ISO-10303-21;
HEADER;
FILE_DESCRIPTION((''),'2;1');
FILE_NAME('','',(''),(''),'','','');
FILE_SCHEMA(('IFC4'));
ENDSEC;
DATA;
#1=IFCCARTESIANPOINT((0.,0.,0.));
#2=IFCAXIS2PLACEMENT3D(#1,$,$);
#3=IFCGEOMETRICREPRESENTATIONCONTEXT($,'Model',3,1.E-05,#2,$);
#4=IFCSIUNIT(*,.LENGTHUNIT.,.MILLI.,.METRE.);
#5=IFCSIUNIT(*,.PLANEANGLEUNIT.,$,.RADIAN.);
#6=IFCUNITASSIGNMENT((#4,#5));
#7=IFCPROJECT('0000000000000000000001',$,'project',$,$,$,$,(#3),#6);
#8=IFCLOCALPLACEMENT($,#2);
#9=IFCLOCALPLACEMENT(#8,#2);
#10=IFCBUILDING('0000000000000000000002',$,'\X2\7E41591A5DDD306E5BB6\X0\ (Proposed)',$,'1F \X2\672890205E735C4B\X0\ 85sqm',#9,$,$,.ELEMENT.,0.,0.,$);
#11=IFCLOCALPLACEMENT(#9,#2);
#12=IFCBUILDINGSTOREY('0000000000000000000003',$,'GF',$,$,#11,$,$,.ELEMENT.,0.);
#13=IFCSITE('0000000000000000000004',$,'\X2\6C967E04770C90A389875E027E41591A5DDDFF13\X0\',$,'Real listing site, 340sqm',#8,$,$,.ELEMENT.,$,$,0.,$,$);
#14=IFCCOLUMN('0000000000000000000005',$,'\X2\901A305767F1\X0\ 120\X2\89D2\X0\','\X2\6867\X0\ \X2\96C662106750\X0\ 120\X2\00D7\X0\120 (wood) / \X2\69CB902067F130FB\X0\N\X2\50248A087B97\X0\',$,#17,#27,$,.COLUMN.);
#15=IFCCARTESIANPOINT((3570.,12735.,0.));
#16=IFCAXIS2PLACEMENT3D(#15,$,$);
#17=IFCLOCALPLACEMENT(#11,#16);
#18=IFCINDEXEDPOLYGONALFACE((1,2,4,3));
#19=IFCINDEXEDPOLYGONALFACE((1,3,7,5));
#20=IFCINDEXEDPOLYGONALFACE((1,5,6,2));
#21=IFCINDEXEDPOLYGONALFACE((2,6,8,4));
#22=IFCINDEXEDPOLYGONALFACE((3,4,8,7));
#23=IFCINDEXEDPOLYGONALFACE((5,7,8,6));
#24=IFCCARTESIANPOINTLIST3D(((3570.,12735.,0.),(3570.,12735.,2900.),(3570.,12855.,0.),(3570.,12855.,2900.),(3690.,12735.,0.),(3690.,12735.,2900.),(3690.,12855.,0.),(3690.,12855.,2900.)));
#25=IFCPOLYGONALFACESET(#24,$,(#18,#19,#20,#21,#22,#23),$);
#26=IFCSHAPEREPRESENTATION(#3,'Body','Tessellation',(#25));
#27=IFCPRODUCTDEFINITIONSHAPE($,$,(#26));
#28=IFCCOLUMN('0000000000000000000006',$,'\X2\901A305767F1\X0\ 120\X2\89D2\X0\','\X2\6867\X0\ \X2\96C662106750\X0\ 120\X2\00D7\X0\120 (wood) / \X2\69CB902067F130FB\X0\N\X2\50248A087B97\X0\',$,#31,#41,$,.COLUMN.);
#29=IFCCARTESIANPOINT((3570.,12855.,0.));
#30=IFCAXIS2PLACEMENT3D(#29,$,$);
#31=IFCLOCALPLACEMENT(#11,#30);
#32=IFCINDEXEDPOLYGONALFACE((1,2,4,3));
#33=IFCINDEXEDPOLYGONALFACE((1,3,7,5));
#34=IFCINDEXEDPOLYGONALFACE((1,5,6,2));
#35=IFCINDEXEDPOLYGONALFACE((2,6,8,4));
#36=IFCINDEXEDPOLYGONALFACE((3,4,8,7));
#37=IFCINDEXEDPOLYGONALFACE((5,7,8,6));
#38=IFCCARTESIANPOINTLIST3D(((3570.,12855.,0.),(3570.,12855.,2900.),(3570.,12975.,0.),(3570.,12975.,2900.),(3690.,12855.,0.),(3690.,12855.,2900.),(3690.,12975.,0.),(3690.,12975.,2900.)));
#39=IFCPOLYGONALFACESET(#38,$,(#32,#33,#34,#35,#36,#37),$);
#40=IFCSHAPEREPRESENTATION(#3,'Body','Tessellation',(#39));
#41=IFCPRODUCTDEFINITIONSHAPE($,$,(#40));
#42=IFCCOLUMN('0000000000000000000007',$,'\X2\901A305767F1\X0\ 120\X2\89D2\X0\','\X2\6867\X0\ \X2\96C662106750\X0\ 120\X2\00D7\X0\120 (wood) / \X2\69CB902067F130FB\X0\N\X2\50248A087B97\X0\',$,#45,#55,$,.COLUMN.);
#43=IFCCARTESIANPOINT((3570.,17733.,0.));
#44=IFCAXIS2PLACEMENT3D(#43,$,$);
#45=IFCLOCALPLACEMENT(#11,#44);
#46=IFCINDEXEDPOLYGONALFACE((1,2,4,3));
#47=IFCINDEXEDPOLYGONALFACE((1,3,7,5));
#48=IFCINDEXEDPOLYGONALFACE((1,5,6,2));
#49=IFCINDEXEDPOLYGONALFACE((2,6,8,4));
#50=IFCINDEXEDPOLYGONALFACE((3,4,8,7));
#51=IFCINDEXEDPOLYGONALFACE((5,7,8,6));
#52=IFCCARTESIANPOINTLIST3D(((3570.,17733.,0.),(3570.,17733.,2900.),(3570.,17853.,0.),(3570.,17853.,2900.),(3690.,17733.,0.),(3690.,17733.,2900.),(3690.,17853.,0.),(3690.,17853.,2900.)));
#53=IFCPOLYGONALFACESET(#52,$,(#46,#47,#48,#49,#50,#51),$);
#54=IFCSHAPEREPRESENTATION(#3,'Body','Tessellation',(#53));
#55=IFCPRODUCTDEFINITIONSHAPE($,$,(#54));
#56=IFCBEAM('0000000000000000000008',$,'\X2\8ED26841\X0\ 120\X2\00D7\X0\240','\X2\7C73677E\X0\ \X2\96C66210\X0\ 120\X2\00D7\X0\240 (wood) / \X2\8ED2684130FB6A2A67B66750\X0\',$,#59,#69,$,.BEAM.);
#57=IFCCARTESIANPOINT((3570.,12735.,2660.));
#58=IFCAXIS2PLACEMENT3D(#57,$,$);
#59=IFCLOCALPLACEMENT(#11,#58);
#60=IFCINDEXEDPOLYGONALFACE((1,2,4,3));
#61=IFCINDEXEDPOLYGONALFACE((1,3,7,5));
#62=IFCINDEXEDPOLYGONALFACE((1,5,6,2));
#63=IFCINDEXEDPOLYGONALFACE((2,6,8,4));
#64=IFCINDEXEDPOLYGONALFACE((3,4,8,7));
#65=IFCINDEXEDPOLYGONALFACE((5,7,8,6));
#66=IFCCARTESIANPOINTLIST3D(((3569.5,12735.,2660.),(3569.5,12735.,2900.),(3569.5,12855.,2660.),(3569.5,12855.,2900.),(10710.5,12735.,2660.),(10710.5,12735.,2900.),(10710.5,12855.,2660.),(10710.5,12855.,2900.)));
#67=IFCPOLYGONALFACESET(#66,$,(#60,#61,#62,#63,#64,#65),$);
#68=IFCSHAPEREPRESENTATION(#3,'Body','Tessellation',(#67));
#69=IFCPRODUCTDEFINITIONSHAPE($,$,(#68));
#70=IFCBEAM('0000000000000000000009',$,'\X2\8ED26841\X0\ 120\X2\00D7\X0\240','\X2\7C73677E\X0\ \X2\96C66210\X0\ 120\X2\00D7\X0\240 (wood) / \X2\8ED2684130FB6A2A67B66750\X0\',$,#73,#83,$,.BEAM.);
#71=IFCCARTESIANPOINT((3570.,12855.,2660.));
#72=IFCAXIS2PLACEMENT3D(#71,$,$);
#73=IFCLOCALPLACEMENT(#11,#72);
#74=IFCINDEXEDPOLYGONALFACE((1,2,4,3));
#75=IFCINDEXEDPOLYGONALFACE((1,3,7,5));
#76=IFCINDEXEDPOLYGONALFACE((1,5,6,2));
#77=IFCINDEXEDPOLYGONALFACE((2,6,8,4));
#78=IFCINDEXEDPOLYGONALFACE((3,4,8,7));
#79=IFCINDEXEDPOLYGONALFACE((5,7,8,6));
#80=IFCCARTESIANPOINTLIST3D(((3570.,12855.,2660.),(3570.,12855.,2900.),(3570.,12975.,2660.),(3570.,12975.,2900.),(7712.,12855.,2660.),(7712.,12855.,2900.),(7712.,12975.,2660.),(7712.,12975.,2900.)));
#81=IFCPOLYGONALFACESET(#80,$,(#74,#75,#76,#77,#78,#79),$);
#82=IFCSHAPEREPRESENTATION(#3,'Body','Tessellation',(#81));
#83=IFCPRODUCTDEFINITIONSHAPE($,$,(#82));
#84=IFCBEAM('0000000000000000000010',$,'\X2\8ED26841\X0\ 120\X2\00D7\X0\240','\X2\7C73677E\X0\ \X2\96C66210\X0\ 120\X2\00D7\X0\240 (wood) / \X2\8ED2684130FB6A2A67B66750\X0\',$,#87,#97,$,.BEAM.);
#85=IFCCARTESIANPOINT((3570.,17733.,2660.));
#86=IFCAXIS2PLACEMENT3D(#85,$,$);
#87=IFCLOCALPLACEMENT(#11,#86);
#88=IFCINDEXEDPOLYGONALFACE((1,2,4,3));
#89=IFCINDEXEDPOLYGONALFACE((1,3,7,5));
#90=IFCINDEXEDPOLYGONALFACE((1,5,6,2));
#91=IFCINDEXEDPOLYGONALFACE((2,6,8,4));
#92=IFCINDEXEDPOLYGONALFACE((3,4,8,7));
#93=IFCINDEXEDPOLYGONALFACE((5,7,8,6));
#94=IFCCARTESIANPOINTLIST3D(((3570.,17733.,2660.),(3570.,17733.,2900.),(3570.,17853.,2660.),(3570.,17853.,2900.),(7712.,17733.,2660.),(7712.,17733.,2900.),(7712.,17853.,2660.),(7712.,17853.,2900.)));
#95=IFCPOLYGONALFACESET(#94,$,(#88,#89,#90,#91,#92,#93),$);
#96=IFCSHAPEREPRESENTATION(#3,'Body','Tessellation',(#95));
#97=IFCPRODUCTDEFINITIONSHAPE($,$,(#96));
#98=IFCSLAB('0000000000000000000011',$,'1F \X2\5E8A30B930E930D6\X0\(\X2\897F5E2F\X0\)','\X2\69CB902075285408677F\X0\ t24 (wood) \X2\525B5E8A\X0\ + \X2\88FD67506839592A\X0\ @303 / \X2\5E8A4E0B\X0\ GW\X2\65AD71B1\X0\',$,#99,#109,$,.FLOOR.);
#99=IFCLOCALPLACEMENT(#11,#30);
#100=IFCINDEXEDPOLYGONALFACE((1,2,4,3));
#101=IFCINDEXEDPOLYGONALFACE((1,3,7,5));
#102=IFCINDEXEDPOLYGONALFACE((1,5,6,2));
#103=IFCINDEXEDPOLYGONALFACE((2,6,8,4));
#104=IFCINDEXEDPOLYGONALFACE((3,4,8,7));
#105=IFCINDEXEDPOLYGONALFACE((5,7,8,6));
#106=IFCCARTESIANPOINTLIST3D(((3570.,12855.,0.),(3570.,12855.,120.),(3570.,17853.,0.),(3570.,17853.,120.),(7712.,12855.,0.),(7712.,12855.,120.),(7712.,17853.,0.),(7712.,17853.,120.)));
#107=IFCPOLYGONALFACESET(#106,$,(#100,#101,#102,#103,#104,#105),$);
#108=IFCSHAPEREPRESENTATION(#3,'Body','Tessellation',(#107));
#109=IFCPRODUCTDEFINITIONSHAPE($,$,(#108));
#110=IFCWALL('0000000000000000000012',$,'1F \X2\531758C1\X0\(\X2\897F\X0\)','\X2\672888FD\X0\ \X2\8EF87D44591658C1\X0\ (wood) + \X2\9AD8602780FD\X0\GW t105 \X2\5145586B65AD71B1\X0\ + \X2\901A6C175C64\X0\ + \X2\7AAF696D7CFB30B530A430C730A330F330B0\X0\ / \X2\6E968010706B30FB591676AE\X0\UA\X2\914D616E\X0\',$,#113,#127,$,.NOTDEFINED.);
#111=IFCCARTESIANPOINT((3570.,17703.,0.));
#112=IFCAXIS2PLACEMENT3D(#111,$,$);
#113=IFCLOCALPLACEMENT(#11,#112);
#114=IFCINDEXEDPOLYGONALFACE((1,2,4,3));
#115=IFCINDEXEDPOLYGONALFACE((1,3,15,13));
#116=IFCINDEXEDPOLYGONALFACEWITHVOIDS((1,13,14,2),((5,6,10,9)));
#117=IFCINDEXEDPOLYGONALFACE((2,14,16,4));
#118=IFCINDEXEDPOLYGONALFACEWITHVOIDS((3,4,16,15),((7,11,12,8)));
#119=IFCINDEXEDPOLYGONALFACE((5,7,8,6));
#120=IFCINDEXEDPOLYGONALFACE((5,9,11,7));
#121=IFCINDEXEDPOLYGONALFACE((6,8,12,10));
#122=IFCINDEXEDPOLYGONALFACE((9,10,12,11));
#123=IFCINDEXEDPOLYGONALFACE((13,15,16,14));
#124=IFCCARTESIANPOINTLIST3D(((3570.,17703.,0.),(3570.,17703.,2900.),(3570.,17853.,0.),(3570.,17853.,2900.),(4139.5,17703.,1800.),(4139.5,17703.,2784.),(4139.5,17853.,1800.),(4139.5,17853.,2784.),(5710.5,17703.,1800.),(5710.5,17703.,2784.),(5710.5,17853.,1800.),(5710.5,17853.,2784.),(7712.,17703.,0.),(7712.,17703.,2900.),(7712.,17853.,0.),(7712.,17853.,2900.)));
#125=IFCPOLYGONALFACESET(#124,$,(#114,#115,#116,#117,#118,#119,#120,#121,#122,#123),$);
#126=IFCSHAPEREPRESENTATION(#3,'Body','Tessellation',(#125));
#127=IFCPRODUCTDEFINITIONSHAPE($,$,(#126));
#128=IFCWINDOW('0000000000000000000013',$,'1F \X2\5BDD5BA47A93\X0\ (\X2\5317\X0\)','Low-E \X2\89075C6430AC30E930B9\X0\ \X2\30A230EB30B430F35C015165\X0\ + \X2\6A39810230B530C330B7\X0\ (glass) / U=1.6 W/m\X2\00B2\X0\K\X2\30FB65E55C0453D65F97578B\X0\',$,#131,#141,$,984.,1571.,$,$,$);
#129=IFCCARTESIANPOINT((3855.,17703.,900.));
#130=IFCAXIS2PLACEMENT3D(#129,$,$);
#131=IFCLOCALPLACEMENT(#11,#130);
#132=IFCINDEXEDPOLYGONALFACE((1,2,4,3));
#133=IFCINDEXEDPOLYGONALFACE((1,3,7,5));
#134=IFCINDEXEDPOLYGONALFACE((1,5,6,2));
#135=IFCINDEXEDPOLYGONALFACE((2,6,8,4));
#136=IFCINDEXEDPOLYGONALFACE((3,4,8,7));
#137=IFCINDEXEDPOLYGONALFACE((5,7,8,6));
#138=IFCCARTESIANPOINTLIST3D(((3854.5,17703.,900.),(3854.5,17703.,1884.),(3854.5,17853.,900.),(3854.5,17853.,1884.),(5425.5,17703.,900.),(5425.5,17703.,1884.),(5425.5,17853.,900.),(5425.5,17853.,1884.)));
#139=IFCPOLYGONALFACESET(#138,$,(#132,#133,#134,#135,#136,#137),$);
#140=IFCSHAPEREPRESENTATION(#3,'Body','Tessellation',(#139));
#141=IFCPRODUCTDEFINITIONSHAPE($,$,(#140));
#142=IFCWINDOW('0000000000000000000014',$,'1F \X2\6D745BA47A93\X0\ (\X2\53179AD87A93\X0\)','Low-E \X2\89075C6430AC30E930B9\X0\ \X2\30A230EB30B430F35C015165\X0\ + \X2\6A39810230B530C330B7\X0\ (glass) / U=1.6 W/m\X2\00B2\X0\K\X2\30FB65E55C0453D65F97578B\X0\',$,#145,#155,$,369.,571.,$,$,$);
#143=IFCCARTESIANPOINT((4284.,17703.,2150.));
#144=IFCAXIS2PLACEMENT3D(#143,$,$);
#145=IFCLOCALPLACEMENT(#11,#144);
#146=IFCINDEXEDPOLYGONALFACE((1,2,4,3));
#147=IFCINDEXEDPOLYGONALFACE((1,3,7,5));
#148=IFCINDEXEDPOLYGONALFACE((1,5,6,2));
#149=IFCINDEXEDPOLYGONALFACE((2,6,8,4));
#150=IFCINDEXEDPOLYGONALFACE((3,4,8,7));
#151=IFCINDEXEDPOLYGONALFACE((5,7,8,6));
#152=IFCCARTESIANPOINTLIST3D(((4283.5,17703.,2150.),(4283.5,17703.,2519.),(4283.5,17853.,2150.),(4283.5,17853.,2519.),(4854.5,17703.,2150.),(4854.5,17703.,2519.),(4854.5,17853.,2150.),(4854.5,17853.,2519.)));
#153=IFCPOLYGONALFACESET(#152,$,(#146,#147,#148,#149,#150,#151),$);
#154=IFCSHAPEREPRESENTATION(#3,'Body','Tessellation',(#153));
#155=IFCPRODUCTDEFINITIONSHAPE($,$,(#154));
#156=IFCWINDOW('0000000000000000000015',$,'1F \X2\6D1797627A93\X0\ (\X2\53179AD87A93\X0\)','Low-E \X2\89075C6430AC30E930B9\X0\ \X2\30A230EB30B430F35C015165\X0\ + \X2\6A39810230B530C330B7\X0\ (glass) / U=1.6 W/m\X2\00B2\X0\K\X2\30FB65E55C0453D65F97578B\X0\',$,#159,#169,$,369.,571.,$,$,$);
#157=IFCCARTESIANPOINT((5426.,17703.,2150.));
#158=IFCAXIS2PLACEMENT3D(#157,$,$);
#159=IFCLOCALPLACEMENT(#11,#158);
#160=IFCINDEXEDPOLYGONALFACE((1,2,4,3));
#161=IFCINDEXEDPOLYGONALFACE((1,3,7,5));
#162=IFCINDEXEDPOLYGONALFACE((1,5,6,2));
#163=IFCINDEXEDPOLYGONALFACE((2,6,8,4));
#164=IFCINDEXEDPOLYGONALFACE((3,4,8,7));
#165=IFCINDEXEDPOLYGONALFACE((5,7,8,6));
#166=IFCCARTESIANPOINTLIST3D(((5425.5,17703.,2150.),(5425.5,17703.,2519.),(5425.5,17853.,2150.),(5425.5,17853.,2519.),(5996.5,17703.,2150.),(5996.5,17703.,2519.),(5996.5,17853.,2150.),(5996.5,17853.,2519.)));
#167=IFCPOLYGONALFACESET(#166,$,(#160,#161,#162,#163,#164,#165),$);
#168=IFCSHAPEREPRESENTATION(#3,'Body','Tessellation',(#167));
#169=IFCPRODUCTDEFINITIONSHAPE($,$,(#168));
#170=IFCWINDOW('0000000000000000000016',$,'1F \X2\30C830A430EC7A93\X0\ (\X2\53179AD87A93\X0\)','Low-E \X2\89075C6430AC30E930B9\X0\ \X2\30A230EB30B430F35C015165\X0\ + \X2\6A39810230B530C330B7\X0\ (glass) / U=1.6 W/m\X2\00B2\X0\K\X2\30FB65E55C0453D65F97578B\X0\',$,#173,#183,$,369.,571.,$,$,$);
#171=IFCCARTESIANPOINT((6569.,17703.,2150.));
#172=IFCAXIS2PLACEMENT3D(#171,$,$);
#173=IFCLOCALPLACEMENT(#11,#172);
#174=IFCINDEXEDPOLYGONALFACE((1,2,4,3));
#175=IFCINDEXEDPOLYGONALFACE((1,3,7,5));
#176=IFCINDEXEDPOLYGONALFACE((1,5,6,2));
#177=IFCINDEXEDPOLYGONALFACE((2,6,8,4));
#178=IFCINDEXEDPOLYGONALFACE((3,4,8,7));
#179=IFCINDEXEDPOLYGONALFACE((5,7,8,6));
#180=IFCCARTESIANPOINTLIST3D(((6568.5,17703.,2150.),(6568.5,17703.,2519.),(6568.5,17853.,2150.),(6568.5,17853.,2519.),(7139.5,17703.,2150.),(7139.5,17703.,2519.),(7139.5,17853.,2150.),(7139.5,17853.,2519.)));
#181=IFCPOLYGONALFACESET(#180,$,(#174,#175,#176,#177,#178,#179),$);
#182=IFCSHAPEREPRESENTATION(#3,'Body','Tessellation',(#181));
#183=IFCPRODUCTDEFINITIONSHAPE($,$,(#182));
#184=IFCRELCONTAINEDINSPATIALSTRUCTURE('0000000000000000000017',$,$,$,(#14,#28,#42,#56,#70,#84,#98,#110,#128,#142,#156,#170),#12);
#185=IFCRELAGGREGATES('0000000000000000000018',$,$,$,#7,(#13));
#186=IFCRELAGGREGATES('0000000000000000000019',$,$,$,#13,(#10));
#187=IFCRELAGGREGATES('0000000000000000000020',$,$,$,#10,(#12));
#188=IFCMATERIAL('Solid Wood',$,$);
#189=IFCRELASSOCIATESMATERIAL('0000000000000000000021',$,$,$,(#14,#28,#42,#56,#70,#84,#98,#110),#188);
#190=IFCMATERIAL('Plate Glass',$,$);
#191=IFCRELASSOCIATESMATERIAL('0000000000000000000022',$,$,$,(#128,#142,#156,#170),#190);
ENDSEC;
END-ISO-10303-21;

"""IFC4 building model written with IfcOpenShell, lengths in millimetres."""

from ifc_helpers import new_model, si_unit, frame, frame_2d, origin, place, context, project, spatial, rectangle, extrude, material, element, fill, save


model = new_model("IFC4")

# Units and contexts
model_context = context("Model", 3, precision=1e-05, world=origin())
ifc_project = project(units=[si_unit("LENGTHUNIT", "METRE", prefix="MILLI"), si_unit("PLANEANGLEUNIT", "RADIAN")], contexts=[model_context])

# Site, building, storey
site_placement = place(None, origin())
site = spatial("IfcSite", under=ifc_project, at=site_placement, Name="沖縄県那覇市繁多川３", ObjectType="Real listing site, 340sqm", CompositionType="ELEMENT", RefElevation=0.0)
building_placement = place(site_placement, origin())
building = spatial("IfcBuilding", under=site, at=building_placement, Name="繁多川の家 (Proposed)", ObjectType="1F 木造平屋 85sqm", CompositionType="ELEMENT", ElevationOfRefHeight=0.0, ElevationOfTerrain=0.0)
storey_placement = place(building_placement, origin())
storey = spatial("IfcBuildingStorey", under=building, at=storey_placement, Name="GF", CompositionType="ELEMENT", Elevation=0.0)

# Columns
ifc_material_1 = material(Name="Solid Wood")
column_1_placement = place(storey_placement, frame((3570.0, 12735.0, 0.0)))
element("IfcColumn", 1, at=column_1_placement, inside=storey, material=ifc_material_1, Name="通し柱 120角", Description="桧 集成材 120×120 (wood) / 構造柱・N値計算", PredefinedType="COLUMN", context=model_context, shape_type="SweptSolid", body=[
    extrude(rectangle(XDim=120.0, YDim=120.0, at=frame_2d((60.0, 60.0))), frame((3570.0, 12735.0, 0.0)), (0.0, 0.0, 1.0), 2900.0),
])
column_2_placement = place(storey_placement, frame((3570.0, 12855.0, 0.0)))
element("IfcColumn", 2, at=column_2_placement, inside=storey, material=ifc_material_1, Name="通し柱 120角", Description="桧 集成材 120×120 (wood) / 構造柱・N値計算", PredefinedType="COLUMN", context=model_context, shape_type="SweptSolid", body=[
    extrude(rectangle(XDim=120.0, YDim=120.0, at=frame_2d((60.0, 60.0))), frame((3570.0, 12855.0, 0.0)), (0.0, 0.0, 1.0), 2900.0),
])
column_3_placement = place(storey_placement, frame((3570.0, 17733.0, 0.0)))
element("IfcColumn", 3, at=column_3_placement, inside=storey, material=ifc_material_1, Name="通し柱 120角", Description="桧 集成材 120×120 (wood) / 構造柱・N値計算", PredefinedType="COLUMN", context=model_context, shape_type="SweptSolid", body=[
    extrude(rectangle(XDim=120.0, YDim=120.0, at=frame_2d((60.0, 60.0))), frame((3570.0, 17733.0, 0.0)), (0.0, 0.0, 1.0), 2900.0),
])

# Beams
beam_1_placement = place(storey_placement, frame((3570.0, 12735.0, 2660.0)))
element("IfcBeam", 4, at=beam_1_placement, inside=storey, material=ifc_material_1, Name="軒桁 120×240", Description="米松 集成 120×240 (wood) / 軒桁・横架材", PredefinedType="BEAM", context=model_context, shape_type="SweptSolid", body=[
    extrude(rectangle(XDim=7141.0, YDim=120.0, at=frame_2d((3570.0, 60.0))), frame((3570.0, 12735.0, 2660.0)), (0.0, 0.0, 1.0), 240.0),
])
beam_2_placement = place(storey_placement, frame((3570.0, 12855.0, 2660.0)))
element("IfcBeam", 5, at=beam_2_placement, inside=storey, material=ifc_material_1, Name="軒桁 120×240", Description="米松 集成 120×240 (wood) / 軒桁・横架材", PredefinedType="BEAM", context=model_context, shape_type="SweptSolid", body=[
    extrude(rectangle(XDim=4142.0, YDim=120.0, at=frame_2d((2071.0, 60.0))), frame((3570.0, 12855.0, 2660.0)), (0.0, 0.0, 1.0), 240.0),
])
beam_3_placement = place(storey_placement, frame((3570.0, 17733.0, 2660.0)))
element("IfcBeam", 6, at=beam_3_placement, inside=storey, material=ifc_material_1, Name="軒桁 120×240", Description="米松 集成 120×240 (wood) / 軒桁・横架材", PredefinedType="BEAM", context=model_context, shape_type="SweptSolid", body=[
    extrude(rectangle(XDim=4142.0, YDim=120.0, at=frame_2d((2071.0, 60.0))), frame((3570.0, 17733.0, 2660.0)), (0.0, 0.0, 1.0), 240.0),
])

# Slab
slab_placement = place(storey_placement, frame((3570.0, 12855.0, 0.0)))
element("IfcSlab", 7, at=slab_placement, inside=storey, material=ifc_material_1, Name="1F 床スラブ(西帯)", Description="構造用合板 t24 (wood) 剛床 + 製材根太 @303 / 床下 GW断熱", PredefinedType="FLOOR", context=model_context, shape_type="SweptSolid", body=[
    extrude(rectangle(XDim=4142.0, YDim=4998.0, at=frame_2d((2071.0, 2499.0))), frame((3570.0, 12855.0, 0.0)), (0.0, 0.0, 1.0), 120.0),
])

# Wall, openings, windows
wall_1_placement = place(storey_placement, frame((3570.0, 17703.0, 0.0)))
wall_1 = element("IfcWall", 8, at=wall_1_placement, inside=storey, material=ifc_material_1, Name="1F 北壁(西)", Description="木製 軸組外壁 (wood) + 高性能GW t105 充填断熱 + 通気層 + 窯業系サイディング / 準耐火・外皮UA配慮", PredefinedType="NOTDEFINED", context=model_context, shape_type="SweptSolid", body=[
    extrude(rectangle(XDim=4142.0, YDim=150.0, at=frame_2d((2071.0, 75.0))), frame((3570.0, 17703.0, 0.0)), (0.0, 0.0, 1.0), 2900.0),
])
opening_1_placement = place(storey_placement, frame((3855.0, 17703.0, 900.0)))
opening_1 = element("IfcOpeningElement", 9, at=opening_1_placement, cuts=wall_1, PredefinedType="NOTDEFINED", context=model_context, shape_type="SweptSolid", body=[
    extrude(rectangle(XDim=1571.0, YDim=150.0, at=frame_2d((785.0, 75.0))), frame((3855.0, 17703.0, 900.0)), (0.0, 0.0, 1.0), 984.0),
])
opening_2_placement = place(storey_placement, frame((4284.0, 17703.0, 2150.0)))
opening_2 = element("IfcOpeningElement", 10, at=opening_2_placement, cuts=wall_1, PredefinedType="NOTDEFINED", context=model_context, shape_type="SweptSolid", body=[
    extrude(rectangle(XDim=571.0, YDim=150.0, at=frame_2d((285.0, 75.0))), frame((4284.0, 17703.0, 2150.0)), (0.0, 0.0, 1.0), 369.0),
])
opening_3_placement = place(storey_placement, frame((5426.0, 17703.0, 2150.0)))
opening_3 = element("IfcOpeningElement", 11, at=opening_3_placement, cuts=wall_1, PredefinedType="NOTDEFINED", context=model_context, shape_type="SweptSolid", body=[
    extrude(rectangle(XDim=571.0, YDim=150.0, at=frame_2d((285.0, 75.0))), frame((5426.0, 17703.0, 2150.0)), (0.0, 0.0, 1.0), 369.0),
])
opening_4_placement = place(storey_placement, frame((6569.0, 17703.0, 2150.0)))
opening_4 = element("IfcOpeningElement", 12, at=opening_4_placement, cuts=wall_1, PredefinedType="NOTDEFINED", context=model_context, shape_type="SweptSolid", body=[
    extrude(rectangle(XDim=571.0, YDim=150.0, at=frame_2d((285.0, 75.0))), frame((6569.0, 17703.0, 2150.0)), (0.0, 0.0, 1.0), 369.0),
])
ifc_material_2 = material(Name="Plate Glass")
window_1_placement = place(storey_placement, frame((3855.0, 17703.0, 900.0)))
window_1 = element("IfcWindow", 13, at=window_1_placement, inside=storey, material=ifc_material_2, Name="1F 寝室窓 (北)", Description="Low-E 複層ガラス アルゴン封入 + 樹脂サッシ (glass) / U=1.6 W/m²K・日射取得型", OverallHeight=984.0, OverallWidth=1571.0, context=model_context, shape_type="SweptSolid", body=[
    extrude(rectangle(XDim=1571.0, YDim=150.0, at=frame_2d((785.0, 75.0))), frame((3855.0, 17703.0, 900.0)), (0.0, 0.0, 1.0), 984.0),
])
fill(opening_1, window_1)
window_2_placement = place(storey_placement, frame((4284.0, 17703.0, 2150.0)))
window_2 = element("IfcWindow", 14, at=window_2_placement, inside=storey, material=ifc_material_2, Name="1F 浴室窓 (北高窓)", Description="Low-E 複層ガラス アルゴン封入 + 樹脂サッシ (glass) / U=1.6 W/m²K・日射取得型", OverallHeight=369.0, OverallWidth=571.0, context=model_context, shape_type="SweptSolid", body=[
    extrude(rectangle(XDim=571.0, YDim=150.0, at=frame_2d((285.0, 75.0))), frame((4284.0, 17703.0, 2150.0)), (0.0, 0.0, 1.0), 369.0),
])
fill(opening_2, window_2)
window_3_placement = place(storey_placement, frame((5426.0, 17703.0, 2150.0)))
window_3 = element("IfcWindow", 15, at=window_3_placement, inside=storey, material=ifc_material_2, Name="1F 洗面窓 (北高窓)", Description="Low-E 複層ガラス アルゴン封入 + 樹脂サッシ (glass) / U=1.6 W/m²K・日射取得型", OverallHeight=369.0, OverallWidth=571.0, context=model_context, shape_type="SweptSolid", body=[
    extrude(rectangle(XDim=571.0, YDim=150.0, at=frame_2d((285.0, 75.0))), frame((5426.0, 17703.0, 2150.0)), (0.0, 0.0, 1.0), 369.0),
])
fill(opening_3, window_3)
window_4_placement = place(storey_placement, frame((6569.0, 17703.0, 2150.0)))
window_4 = element("IfcWindow", 16, at=window_4_placement, inside=storey, material=ifc_material_2, Name="1F トイレ窓 (北高窓)", Description="Low-E 複層ガラス アルゴン封入 + 樹脂サッシ (glass) / U=1.6 W/m²K・日射取得型", OverallHeight=369.0, OverallWidth=571.0, context=model_context, shape_type="SweptSolid", body=[
    extrude(rectangle(XDim=571.0, YDim=150.0, at=frame_2d((285.0, 75.0))), frame((6569.0, 17703.0, 2150.0)), (0.0, 0.0, 1.0), 369.0),
])
fill(opening_4, window_4)

save(model, "model.ifc")
